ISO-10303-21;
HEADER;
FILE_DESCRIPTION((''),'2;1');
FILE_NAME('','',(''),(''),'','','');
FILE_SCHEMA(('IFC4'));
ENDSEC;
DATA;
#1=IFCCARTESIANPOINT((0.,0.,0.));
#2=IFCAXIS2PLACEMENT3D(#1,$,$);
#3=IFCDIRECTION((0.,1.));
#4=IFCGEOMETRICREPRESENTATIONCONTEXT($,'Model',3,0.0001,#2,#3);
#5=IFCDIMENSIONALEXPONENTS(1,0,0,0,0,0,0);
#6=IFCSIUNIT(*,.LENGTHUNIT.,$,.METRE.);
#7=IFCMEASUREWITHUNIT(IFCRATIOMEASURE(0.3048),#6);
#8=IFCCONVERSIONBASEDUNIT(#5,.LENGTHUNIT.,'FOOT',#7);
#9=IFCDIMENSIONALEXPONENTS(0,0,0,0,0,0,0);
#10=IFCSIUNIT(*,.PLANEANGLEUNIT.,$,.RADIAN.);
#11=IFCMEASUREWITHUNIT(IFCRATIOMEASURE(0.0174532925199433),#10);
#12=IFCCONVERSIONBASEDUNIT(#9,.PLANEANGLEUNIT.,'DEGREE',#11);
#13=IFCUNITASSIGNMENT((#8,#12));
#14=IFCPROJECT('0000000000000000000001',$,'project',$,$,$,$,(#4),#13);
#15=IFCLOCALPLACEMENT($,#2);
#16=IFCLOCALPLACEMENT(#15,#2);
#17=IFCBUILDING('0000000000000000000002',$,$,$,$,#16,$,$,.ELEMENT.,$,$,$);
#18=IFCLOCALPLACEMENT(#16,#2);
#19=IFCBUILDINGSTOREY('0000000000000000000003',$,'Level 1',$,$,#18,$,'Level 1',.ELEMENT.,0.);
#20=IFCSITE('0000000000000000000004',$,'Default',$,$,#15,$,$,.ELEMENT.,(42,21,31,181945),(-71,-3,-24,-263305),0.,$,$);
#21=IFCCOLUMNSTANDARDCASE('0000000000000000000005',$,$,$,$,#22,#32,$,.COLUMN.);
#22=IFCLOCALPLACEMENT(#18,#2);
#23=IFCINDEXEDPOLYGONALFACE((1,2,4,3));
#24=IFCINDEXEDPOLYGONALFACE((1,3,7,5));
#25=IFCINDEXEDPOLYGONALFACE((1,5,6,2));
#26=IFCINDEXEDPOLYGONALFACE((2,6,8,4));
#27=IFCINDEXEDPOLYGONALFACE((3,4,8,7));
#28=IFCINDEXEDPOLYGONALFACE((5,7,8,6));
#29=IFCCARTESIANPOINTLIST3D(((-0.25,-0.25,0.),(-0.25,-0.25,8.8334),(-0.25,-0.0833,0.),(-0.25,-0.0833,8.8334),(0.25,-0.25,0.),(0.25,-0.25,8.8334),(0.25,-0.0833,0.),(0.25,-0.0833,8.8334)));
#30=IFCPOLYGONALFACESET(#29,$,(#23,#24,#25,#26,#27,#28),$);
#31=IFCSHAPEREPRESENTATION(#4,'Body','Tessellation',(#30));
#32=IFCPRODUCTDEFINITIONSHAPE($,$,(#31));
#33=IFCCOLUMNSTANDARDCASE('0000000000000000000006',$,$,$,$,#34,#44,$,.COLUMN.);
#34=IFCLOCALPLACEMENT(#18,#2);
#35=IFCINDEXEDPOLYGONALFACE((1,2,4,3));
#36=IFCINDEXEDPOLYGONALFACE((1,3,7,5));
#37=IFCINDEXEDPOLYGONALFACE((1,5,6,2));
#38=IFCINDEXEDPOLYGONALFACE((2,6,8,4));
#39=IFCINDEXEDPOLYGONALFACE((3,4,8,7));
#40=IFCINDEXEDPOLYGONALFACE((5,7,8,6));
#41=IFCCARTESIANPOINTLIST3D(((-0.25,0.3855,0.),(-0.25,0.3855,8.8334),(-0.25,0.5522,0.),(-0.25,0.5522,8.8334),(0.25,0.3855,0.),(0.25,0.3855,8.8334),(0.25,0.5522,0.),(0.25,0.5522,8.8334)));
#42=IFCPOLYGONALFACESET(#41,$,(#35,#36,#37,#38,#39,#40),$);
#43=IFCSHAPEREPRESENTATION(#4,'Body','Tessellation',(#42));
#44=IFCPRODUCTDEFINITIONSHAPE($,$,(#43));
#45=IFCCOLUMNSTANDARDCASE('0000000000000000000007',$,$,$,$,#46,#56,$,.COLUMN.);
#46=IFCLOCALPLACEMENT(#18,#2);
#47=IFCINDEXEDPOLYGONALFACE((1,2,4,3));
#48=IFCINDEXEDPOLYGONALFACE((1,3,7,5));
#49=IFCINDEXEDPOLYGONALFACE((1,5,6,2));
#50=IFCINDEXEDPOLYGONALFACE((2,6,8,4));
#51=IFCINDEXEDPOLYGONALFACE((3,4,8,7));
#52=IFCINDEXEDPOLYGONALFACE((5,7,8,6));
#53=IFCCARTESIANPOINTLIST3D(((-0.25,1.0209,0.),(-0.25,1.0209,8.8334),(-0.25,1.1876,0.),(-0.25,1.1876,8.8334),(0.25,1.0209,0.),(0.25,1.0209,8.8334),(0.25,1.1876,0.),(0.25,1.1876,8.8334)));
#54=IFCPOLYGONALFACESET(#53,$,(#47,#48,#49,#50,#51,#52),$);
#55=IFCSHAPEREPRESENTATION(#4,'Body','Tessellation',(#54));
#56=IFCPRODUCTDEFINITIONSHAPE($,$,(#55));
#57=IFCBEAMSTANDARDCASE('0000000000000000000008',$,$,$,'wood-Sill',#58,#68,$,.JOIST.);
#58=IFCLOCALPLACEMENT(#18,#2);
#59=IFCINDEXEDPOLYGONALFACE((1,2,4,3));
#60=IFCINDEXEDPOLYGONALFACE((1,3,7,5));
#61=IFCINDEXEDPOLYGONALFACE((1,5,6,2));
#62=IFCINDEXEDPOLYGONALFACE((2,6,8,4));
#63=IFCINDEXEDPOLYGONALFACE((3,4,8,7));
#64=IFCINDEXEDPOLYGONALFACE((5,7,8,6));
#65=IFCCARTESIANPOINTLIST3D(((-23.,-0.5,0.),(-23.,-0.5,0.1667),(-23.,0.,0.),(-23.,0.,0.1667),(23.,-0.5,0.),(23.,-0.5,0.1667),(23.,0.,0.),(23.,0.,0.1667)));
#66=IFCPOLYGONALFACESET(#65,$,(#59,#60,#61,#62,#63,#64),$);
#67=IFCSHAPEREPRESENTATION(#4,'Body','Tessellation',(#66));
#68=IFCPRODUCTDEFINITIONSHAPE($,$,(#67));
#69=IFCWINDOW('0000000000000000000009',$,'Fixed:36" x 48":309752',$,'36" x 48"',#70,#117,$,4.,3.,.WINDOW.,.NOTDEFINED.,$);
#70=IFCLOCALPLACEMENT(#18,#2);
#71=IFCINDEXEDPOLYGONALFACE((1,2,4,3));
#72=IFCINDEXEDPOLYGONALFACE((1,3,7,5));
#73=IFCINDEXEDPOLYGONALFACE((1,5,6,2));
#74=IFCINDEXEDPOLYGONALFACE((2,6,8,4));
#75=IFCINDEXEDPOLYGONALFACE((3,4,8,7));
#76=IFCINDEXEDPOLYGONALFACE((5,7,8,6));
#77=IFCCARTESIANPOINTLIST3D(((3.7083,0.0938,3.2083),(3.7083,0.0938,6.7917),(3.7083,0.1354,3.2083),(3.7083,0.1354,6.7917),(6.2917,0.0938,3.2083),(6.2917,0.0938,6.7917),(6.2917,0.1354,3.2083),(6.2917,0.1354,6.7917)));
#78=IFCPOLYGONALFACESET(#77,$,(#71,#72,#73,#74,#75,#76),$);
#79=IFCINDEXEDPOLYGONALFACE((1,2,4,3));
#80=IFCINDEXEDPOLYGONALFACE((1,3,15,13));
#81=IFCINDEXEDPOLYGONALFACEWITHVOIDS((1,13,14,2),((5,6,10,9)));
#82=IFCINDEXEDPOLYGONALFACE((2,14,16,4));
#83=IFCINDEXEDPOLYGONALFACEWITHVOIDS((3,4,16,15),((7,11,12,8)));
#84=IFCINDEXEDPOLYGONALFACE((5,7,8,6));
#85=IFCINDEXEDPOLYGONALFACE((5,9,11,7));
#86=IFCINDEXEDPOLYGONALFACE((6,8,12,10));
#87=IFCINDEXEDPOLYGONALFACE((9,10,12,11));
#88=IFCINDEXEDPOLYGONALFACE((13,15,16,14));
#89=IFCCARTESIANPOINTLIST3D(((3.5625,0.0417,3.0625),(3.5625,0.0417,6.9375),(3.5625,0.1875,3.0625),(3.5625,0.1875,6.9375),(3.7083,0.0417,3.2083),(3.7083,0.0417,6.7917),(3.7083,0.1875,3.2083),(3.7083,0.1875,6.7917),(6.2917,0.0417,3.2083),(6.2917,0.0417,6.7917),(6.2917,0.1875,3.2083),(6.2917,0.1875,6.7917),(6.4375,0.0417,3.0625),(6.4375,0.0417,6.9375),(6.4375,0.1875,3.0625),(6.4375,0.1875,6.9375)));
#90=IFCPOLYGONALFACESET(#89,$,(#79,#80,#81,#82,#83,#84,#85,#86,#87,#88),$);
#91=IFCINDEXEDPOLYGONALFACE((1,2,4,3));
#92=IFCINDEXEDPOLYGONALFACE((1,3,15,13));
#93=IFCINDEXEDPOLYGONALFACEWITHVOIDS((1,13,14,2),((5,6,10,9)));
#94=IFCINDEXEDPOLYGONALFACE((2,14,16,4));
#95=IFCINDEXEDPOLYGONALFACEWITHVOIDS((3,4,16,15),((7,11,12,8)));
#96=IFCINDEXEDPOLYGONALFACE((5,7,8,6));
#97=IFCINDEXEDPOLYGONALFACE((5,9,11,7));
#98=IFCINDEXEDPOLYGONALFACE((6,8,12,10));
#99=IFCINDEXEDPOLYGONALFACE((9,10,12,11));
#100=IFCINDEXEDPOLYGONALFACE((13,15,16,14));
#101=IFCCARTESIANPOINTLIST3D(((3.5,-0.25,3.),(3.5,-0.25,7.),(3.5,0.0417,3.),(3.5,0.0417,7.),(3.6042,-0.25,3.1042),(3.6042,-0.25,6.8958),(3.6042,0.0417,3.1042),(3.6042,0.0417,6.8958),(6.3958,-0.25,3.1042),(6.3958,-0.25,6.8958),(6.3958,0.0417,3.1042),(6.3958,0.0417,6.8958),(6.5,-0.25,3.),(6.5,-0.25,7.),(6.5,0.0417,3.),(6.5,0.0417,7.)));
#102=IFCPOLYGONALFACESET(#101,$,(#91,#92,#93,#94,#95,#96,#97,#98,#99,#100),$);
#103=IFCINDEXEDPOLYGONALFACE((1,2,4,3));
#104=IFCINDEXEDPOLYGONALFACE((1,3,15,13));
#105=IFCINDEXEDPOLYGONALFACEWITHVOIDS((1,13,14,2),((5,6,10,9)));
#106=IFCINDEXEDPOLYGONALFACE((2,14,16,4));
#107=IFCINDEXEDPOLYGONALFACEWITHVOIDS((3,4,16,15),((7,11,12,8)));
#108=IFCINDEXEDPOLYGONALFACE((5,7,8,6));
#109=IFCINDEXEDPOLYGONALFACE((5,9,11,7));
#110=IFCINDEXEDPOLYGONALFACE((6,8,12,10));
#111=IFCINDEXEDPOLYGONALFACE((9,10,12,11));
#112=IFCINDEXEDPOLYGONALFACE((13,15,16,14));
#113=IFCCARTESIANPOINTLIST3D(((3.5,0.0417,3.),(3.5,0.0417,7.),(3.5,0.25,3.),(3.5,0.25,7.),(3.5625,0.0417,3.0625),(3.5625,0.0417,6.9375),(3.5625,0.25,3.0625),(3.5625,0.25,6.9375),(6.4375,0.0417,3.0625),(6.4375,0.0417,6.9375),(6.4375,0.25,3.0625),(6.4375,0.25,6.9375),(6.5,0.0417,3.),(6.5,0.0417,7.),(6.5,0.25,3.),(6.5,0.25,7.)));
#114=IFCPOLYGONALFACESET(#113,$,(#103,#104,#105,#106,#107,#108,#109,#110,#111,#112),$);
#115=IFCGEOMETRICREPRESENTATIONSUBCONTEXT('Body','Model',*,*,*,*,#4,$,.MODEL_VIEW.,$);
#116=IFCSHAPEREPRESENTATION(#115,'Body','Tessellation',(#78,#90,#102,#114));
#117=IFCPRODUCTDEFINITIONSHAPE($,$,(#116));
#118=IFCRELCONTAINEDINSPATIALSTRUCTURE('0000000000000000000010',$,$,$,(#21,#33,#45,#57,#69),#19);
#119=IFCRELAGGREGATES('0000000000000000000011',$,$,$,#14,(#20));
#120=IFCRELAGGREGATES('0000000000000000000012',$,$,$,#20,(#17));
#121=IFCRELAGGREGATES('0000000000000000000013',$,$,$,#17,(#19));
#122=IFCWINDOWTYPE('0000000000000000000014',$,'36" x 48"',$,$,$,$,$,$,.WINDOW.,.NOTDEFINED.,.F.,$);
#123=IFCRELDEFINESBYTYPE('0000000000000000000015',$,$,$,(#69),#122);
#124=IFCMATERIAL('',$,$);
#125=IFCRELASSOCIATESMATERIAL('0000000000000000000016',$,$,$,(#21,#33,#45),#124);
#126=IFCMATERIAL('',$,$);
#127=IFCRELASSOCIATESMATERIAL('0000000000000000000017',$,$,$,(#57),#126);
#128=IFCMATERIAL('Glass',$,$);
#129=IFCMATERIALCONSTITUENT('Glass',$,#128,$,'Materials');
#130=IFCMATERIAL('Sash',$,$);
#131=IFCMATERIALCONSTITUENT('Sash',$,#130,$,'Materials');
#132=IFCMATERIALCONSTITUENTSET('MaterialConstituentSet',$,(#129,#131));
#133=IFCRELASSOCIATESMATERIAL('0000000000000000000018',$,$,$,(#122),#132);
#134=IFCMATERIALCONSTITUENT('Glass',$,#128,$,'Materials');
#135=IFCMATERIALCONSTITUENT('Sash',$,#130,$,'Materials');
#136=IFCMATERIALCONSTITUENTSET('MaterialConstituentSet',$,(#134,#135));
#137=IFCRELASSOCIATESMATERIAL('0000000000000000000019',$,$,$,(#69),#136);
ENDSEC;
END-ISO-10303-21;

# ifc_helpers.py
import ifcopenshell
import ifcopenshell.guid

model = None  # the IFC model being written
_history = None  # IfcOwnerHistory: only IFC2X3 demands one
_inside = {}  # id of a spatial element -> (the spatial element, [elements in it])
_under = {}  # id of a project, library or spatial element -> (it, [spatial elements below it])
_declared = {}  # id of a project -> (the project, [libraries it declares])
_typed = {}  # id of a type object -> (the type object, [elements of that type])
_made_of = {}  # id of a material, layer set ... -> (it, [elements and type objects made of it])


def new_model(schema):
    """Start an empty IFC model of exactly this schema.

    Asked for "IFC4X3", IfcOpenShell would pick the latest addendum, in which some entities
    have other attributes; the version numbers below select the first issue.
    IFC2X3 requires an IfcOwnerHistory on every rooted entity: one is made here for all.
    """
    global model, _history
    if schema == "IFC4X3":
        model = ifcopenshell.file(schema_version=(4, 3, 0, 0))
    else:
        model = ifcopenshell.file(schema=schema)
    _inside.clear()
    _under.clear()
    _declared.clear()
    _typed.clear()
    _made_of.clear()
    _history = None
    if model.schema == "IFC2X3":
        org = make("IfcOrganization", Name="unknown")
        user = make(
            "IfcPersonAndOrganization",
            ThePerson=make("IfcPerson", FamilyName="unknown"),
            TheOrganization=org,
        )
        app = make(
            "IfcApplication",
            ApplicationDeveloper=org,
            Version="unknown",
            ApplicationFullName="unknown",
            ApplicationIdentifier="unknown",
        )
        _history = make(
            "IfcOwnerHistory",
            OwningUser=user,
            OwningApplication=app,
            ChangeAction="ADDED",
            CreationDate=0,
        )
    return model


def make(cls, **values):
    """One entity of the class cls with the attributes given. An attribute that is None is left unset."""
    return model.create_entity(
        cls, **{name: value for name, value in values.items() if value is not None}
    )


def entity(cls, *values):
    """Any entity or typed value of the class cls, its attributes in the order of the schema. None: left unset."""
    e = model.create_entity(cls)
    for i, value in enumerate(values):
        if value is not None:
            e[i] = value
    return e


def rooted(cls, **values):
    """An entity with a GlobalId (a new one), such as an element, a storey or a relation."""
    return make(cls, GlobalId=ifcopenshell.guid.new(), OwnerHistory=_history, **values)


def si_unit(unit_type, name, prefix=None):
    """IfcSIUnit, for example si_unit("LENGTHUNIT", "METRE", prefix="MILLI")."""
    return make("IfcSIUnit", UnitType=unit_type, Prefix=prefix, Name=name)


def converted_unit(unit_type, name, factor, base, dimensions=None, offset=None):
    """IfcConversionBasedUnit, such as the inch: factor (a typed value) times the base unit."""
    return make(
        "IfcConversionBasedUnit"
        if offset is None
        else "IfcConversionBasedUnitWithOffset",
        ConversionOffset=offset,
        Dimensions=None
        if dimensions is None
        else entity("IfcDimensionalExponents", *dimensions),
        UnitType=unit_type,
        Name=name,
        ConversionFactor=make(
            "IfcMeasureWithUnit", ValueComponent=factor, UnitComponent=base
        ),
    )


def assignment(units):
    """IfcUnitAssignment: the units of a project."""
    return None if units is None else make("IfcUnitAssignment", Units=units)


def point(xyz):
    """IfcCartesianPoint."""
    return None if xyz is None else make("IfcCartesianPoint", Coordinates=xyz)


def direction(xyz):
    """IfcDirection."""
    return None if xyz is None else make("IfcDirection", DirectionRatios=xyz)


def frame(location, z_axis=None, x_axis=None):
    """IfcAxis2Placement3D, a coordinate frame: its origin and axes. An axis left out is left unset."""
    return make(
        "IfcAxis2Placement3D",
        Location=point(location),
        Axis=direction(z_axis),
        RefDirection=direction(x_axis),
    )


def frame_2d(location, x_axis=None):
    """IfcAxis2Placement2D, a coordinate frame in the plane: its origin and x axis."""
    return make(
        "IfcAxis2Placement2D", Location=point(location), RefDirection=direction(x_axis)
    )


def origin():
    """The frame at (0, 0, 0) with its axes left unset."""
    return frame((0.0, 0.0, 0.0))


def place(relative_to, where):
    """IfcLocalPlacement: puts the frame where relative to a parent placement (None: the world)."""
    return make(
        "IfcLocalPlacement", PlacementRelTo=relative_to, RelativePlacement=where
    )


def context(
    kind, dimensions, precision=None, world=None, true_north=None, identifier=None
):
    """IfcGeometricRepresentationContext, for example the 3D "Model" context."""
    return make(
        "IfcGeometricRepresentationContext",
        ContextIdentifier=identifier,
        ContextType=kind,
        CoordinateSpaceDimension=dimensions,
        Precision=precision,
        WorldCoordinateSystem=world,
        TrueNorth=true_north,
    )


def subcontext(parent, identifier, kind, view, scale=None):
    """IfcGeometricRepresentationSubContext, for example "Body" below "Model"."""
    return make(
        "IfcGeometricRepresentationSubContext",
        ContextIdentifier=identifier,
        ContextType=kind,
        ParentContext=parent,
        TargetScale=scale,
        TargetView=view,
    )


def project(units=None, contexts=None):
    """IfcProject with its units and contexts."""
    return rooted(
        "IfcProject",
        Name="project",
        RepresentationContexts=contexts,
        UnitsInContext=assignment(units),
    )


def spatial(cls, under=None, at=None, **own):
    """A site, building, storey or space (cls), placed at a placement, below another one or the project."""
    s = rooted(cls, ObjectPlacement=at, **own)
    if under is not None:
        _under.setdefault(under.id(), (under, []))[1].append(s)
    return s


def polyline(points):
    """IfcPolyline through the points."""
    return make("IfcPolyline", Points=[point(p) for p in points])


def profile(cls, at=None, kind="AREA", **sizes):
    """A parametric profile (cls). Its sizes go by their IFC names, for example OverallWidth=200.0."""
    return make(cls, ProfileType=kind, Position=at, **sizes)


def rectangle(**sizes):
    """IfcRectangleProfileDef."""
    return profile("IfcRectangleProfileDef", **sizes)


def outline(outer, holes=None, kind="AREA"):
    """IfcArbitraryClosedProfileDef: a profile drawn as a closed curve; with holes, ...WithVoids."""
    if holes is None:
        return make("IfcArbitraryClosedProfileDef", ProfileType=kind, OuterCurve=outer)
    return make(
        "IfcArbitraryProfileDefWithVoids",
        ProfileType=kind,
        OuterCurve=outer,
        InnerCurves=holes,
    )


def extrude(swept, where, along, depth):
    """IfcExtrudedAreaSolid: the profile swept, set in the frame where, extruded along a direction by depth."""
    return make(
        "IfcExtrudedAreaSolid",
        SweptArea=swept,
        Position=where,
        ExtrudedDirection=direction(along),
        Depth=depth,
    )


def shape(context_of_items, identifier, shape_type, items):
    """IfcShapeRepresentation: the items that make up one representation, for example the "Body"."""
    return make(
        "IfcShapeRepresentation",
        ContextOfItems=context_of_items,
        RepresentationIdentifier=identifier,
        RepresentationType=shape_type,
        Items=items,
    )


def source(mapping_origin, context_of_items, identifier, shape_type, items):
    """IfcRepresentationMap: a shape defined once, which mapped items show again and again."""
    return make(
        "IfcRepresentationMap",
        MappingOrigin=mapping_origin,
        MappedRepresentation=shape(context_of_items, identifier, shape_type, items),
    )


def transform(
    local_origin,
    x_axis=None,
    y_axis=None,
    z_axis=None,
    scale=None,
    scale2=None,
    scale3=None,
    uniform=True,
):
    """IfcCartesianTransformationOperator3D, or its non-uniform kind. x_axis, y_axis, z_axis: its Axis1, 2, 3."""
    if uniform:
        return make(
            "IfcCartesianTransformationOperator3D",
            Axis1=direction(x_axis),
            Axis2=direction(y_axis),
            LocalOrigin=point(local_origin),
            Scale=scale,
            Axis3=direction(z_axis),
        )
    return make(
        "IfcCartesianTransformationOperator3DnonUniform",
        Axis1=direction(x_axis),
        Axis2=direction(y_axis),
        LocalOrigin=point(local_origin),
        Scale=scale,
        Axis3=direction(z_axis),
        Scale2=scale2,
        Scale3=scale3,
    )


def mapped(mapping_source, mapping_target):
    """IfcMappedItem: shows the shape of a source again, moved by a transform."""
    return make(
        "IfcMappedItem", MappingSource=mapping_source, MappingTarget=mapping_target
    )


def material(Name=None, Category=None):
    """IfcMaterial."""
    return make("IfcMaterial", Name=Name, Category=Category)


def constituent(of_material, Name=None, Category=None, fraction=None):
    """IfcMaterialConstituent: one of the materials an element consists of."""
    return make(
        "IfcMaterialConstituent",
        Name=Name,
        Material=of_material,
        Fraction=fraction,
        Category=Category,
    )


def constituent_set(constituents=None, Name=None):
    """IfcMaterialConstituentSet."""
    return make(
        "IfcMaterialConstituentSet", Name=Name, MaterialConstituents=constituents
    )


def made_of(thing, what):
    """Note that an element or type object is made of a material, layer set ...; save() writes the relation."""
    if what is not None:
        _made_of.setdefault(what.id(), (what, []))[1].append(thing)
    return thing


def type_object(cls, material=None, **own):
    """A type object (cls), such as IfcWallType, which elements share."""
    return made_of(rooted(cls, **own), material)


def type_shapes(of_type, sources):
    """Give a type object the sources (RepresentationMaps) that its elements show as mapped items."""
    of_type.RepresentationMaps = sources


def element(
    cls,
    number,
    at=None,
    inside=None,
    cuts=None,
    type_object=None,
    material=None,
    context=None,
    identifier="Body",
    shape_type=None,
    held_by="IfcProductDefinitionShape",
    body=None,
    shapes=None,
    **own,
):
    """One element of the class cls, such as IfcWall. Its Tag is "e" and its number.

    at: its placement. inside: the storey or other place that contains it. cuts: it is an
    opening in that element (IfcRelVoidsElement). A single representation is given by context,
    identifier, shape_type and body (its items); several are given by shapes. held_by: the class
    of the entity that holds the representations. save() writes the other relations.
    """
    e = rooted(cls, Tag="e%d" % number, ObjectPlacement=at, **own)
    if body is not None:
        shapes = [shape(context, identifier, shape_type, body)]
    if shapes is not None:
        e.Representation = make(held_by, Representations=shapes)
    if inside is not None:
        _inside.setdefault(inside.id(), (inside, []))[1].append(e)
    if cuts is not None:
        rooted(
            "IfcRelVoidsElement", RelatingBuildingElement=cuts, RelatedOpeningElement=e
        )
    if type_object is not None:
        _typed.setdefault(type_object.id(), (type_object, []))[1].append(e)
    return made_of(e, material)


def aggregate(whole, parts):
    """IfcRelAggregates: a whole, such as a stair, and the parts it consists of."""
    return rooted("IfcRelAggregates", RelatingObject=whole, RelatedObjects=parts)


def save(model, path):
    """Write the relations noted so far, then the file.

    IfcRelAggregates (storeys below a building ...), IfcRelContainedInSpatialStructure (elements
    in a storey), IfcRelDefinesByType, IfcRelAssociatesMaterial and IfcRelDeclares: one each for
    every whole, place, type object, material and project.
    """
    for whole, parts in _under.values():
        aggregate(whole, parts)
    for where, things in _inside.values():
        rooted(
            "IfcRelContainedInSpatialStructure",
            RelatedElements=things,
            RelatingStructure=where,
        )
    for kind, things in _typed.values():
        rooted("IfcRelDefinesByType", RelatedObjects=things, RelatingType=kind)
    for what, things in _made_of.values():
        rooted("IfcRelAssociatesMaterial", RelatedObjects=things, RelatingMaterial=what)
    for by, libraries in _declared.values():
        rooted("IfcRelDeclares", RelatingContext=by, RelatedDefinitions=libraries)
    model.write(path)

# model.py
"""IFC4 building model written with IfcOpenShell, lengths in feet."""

from ifc_helpers import new_model, entity, si_unit, converted_unit, direction, frame, frame_2d, origin, place, context, subcontext, project, spatial, polyline, rectangle, outline, extrude, source, transform, mapped, material, constituent, constituent_set, type_object, type_shapes, element, save


model = new_model("IFC4")

# Units and contexts
model_context = context("Model", 3, precision=0.0001, world=origin(), true_north=direction((0.0, 1.0)))
body_context = subcontext(model_context, "Body", "Model", "MODEL_VIEW")
ifc_project = project(units=[converted_unit("LENGTHUNIT", "FOOT", entity("IfcRatioMeasure", 0.3048), si_unit("LENGTHUNIT", "METRE"), dimensions=[1, 0, 0, 0, 0, 0, 0]), converted_unit("PLANEANGLEUNIT", "DEGREE", entity("IfcRatioMeasure", 0.0174532925199433), si_unit("PLANEANGLEUNIT", "RADIAN"), dimensions=[0, 0, 0, 0, 0, 0, 0])], contexts=[model_context])

# Site, building, storey
site_placement = place(None, origin())
site = spatial("IfcSite", under=ifc_project, at=site_placement, Name="Default", CompositionType="ELEMENT", RefLatitude=(42, 21, 31, 181945), RefLongitude=(-71, -3, -24, -263305), RefElevation=0.0)
building_placement = place(site_placement, origin())
building = spatial("IfcBuilding", under=site, at=building_placement, CompositionType="ELEMENT")
storey_placement = place(building_placement, origin())
storey = spatial("IfcBuildingStorey", under=building, at=storey_placement, Name="Level 1", LongName="Level 1", CompositionType="ELEMENT", Elevation=0.0)

# Columns
ifc_material_1 = material(Name="")
placement_1 = place(storey_placement, frame((0.0, -0.25, 0.0), z_axis=(0.0, 0.0, 1.0), x_axis=(0.0, 1.0, 0.0)))
for number, where, z_axis, x_axis in (
    (1, (0.0833, 0.0, 0.0), (0.0, 0.0, 1.0), (1.0, 0.0, 0.0)),
    (2, (0.7188, 0.0, 0.0), (0.0, 0.0, 1.0), (1.0, 0.0, 0.0)),
    (3, (1.3542, 0.0, 0.0), (0.0, 0.0, 1.0), (1.0, 0.0, 0.0)),
):
    element("IfcColumnStandardCase", number, at=place(placement_1, frame(where, z_axis=z_axis, x_axis=x_axis)), inside=storey, material=ifc_material_1, PredefinedType="COLUMN", context=model_context, shape_type="SweptSolid", body=[
        extrude(rectangle(XDim=0.1667, YDim=0.5), origin(), (0.0, 0.0, 1.0), 8.8334),
    ])
placement_2 = place(storey_placement, frame((46.25, 0.0, 0.0), z_axis=(0.0, 0.0, 1.0), x_axis=(-1.0, 0.0, 0.0)))

# Beam
ifc_material_2 = material(Name="")
beam_1_placement = place(placement_1, frame((0.0, 0.0, 0.0), z_axis=(0.0, 0.0, 1.0), x_axis=(0.0, 1.0, 0.0)))
element("IfcBeamStandardCase", 4, at=beam_1_placement, inside=storey, material=ifc_material_2, ObjectType="wood-Sill", PredefinedType="JOIST", context=model_context, shape_type="SweptSolid", body=[
    extrude(rectangle(XDim=46.0, YDim=0.5), origin(), (0.0, 0.0, 1.0), 0.1667),
])

# Window
ifc_material_3 = material(Name="Glass")
ifc_constituent_1 = constituent(ifc_material_3, Name="Glass", Category="Materials")
ifc_material_4 = material(Name="Sash")
ifc_constituent_2 = constituent(ifc_material_4, Name="Sash", Category="Materials")
ifc_constituent_set_1 = constituent_set(constituents=[ifc_constituent_1, ifc_constituent_2], Name="MaterialConstituentSet")
ifc_constituent_3 = constituent(ifc_material_3, Name="Glass", Category="Materials")
ifc_constituent_4 = constituent(ifc_material_4, Name="Sash", Category="Materials")
ifc_constituent_set_2 = constituent_set(constituents=[ifc_constituent_3, ifc_constituent_4], Name="MaterialConstituentSet")
window_type = type_object("IfcWindowType", Name="36\" x 48\"", ParameterTakesPrecedence=False, PartitioningType="NOTDEFINED", PredefinedType="WINDOW", material=ifc_constituent_set_2)
shared_shape = source(origin(), body_context, "Body", "SweptSolid", [
    extrude(rectangle(XDim=0.0417, YDim=2.5833, at=frame_2d((0.0, 0.0), x_axis=(1.0, 0.0))), frame((1.5, 0.3646, 0.2083), z_axis=(0.0, 0.0, 1.0), x_axis=(0.0, 1.0, 0.0)), (0.0, 0.0, 1.0), 3.5833),
    extrude(outline(polyline([(-1.4375, -1.9375), (1.4375, -1.9375), (1.4375, 1.9375), (-1.4375, 1.9375), (-1.4375, -1.9375)]), holes=[polyline([(-1.2917, -1.7917), (-1.2917, 1.7917), (1.2917, 1.7917), (1.2917, -1.7917), (-1.2917, -1.7917)])]), frame((1.5, 0.2917, 2.0), z_axis=(0.0, 1.0, 0.0), x_axis=(1.0, 0.0, 0.0)), (0.0, 0.0, 1.0), 0.1458),
    extrude(outline(polyline([(-1.5, -2.0), (1.5, -2.0), (1.5, 2.0), (-1.5, 2.0), (-1.5, -2.0)]), holes=[polyline([(-1.3958, -1.8958), (-1.3958, 1.8958), (1.3958, 1.8958), (1.3958, -1.8958), (-1.3958, -1.8958)])]), frame((1.5, 0.0, 2.0), z_axis=(0.0, 1.0, 0.0), x_axis=(1.0, 0.0, 0.0)), (0.0, 0.0, 1.0), 0.2917),
    extrude(outline(polyline([(-2.0, -1.5), (2.0, -1.5), (2.0, 1.5), (-2.0, 1.5), (-2.0, -1.5)]), holes=[polyline([(-1.9375, -1.4375), (-1.9375, 1.4375), (1.9375, 1.4375), (1.9375, -1.4375), (-1.9375, -1.4375)])]), frame((1.5, 0.2917, 2.0), z_axis=(0.0, 1.0, 0.0), x_axis=(0.0, 0.0, -1.0)), (0.0, 0.0, 1.0), 0.2083),
])
type_shapes(window_type, [shared_shape])
placement_3 = place(placement_2, frame((42.75, 0.25, 3.0)))
window_placement = place(placement_3, frame((0.0, 0.0, 0.0), z_axis=(0.0, 0.0, 1.0), x_axis=(-1.0, 0.0, 0.0)))
element("IfcWindow", 5, at=window_placement, inside=storey, type_object=window_type, material=ifc_constituent_set_1, Name="Fixed:36\" x 48\":309752", ObjectType="36\" x 48\"", OverallHeight=4.0, OverallWidth=3.0, PartitioningType="NOTDEFINED", PredefinedType="WINDOW", context=body_context, shape_type="MappedRepresentation", body=[
    mapped(shared_shape, transform((0.0, 0.0, 0.0), scale=1.0)),
])

save(model, "model.ifc")
